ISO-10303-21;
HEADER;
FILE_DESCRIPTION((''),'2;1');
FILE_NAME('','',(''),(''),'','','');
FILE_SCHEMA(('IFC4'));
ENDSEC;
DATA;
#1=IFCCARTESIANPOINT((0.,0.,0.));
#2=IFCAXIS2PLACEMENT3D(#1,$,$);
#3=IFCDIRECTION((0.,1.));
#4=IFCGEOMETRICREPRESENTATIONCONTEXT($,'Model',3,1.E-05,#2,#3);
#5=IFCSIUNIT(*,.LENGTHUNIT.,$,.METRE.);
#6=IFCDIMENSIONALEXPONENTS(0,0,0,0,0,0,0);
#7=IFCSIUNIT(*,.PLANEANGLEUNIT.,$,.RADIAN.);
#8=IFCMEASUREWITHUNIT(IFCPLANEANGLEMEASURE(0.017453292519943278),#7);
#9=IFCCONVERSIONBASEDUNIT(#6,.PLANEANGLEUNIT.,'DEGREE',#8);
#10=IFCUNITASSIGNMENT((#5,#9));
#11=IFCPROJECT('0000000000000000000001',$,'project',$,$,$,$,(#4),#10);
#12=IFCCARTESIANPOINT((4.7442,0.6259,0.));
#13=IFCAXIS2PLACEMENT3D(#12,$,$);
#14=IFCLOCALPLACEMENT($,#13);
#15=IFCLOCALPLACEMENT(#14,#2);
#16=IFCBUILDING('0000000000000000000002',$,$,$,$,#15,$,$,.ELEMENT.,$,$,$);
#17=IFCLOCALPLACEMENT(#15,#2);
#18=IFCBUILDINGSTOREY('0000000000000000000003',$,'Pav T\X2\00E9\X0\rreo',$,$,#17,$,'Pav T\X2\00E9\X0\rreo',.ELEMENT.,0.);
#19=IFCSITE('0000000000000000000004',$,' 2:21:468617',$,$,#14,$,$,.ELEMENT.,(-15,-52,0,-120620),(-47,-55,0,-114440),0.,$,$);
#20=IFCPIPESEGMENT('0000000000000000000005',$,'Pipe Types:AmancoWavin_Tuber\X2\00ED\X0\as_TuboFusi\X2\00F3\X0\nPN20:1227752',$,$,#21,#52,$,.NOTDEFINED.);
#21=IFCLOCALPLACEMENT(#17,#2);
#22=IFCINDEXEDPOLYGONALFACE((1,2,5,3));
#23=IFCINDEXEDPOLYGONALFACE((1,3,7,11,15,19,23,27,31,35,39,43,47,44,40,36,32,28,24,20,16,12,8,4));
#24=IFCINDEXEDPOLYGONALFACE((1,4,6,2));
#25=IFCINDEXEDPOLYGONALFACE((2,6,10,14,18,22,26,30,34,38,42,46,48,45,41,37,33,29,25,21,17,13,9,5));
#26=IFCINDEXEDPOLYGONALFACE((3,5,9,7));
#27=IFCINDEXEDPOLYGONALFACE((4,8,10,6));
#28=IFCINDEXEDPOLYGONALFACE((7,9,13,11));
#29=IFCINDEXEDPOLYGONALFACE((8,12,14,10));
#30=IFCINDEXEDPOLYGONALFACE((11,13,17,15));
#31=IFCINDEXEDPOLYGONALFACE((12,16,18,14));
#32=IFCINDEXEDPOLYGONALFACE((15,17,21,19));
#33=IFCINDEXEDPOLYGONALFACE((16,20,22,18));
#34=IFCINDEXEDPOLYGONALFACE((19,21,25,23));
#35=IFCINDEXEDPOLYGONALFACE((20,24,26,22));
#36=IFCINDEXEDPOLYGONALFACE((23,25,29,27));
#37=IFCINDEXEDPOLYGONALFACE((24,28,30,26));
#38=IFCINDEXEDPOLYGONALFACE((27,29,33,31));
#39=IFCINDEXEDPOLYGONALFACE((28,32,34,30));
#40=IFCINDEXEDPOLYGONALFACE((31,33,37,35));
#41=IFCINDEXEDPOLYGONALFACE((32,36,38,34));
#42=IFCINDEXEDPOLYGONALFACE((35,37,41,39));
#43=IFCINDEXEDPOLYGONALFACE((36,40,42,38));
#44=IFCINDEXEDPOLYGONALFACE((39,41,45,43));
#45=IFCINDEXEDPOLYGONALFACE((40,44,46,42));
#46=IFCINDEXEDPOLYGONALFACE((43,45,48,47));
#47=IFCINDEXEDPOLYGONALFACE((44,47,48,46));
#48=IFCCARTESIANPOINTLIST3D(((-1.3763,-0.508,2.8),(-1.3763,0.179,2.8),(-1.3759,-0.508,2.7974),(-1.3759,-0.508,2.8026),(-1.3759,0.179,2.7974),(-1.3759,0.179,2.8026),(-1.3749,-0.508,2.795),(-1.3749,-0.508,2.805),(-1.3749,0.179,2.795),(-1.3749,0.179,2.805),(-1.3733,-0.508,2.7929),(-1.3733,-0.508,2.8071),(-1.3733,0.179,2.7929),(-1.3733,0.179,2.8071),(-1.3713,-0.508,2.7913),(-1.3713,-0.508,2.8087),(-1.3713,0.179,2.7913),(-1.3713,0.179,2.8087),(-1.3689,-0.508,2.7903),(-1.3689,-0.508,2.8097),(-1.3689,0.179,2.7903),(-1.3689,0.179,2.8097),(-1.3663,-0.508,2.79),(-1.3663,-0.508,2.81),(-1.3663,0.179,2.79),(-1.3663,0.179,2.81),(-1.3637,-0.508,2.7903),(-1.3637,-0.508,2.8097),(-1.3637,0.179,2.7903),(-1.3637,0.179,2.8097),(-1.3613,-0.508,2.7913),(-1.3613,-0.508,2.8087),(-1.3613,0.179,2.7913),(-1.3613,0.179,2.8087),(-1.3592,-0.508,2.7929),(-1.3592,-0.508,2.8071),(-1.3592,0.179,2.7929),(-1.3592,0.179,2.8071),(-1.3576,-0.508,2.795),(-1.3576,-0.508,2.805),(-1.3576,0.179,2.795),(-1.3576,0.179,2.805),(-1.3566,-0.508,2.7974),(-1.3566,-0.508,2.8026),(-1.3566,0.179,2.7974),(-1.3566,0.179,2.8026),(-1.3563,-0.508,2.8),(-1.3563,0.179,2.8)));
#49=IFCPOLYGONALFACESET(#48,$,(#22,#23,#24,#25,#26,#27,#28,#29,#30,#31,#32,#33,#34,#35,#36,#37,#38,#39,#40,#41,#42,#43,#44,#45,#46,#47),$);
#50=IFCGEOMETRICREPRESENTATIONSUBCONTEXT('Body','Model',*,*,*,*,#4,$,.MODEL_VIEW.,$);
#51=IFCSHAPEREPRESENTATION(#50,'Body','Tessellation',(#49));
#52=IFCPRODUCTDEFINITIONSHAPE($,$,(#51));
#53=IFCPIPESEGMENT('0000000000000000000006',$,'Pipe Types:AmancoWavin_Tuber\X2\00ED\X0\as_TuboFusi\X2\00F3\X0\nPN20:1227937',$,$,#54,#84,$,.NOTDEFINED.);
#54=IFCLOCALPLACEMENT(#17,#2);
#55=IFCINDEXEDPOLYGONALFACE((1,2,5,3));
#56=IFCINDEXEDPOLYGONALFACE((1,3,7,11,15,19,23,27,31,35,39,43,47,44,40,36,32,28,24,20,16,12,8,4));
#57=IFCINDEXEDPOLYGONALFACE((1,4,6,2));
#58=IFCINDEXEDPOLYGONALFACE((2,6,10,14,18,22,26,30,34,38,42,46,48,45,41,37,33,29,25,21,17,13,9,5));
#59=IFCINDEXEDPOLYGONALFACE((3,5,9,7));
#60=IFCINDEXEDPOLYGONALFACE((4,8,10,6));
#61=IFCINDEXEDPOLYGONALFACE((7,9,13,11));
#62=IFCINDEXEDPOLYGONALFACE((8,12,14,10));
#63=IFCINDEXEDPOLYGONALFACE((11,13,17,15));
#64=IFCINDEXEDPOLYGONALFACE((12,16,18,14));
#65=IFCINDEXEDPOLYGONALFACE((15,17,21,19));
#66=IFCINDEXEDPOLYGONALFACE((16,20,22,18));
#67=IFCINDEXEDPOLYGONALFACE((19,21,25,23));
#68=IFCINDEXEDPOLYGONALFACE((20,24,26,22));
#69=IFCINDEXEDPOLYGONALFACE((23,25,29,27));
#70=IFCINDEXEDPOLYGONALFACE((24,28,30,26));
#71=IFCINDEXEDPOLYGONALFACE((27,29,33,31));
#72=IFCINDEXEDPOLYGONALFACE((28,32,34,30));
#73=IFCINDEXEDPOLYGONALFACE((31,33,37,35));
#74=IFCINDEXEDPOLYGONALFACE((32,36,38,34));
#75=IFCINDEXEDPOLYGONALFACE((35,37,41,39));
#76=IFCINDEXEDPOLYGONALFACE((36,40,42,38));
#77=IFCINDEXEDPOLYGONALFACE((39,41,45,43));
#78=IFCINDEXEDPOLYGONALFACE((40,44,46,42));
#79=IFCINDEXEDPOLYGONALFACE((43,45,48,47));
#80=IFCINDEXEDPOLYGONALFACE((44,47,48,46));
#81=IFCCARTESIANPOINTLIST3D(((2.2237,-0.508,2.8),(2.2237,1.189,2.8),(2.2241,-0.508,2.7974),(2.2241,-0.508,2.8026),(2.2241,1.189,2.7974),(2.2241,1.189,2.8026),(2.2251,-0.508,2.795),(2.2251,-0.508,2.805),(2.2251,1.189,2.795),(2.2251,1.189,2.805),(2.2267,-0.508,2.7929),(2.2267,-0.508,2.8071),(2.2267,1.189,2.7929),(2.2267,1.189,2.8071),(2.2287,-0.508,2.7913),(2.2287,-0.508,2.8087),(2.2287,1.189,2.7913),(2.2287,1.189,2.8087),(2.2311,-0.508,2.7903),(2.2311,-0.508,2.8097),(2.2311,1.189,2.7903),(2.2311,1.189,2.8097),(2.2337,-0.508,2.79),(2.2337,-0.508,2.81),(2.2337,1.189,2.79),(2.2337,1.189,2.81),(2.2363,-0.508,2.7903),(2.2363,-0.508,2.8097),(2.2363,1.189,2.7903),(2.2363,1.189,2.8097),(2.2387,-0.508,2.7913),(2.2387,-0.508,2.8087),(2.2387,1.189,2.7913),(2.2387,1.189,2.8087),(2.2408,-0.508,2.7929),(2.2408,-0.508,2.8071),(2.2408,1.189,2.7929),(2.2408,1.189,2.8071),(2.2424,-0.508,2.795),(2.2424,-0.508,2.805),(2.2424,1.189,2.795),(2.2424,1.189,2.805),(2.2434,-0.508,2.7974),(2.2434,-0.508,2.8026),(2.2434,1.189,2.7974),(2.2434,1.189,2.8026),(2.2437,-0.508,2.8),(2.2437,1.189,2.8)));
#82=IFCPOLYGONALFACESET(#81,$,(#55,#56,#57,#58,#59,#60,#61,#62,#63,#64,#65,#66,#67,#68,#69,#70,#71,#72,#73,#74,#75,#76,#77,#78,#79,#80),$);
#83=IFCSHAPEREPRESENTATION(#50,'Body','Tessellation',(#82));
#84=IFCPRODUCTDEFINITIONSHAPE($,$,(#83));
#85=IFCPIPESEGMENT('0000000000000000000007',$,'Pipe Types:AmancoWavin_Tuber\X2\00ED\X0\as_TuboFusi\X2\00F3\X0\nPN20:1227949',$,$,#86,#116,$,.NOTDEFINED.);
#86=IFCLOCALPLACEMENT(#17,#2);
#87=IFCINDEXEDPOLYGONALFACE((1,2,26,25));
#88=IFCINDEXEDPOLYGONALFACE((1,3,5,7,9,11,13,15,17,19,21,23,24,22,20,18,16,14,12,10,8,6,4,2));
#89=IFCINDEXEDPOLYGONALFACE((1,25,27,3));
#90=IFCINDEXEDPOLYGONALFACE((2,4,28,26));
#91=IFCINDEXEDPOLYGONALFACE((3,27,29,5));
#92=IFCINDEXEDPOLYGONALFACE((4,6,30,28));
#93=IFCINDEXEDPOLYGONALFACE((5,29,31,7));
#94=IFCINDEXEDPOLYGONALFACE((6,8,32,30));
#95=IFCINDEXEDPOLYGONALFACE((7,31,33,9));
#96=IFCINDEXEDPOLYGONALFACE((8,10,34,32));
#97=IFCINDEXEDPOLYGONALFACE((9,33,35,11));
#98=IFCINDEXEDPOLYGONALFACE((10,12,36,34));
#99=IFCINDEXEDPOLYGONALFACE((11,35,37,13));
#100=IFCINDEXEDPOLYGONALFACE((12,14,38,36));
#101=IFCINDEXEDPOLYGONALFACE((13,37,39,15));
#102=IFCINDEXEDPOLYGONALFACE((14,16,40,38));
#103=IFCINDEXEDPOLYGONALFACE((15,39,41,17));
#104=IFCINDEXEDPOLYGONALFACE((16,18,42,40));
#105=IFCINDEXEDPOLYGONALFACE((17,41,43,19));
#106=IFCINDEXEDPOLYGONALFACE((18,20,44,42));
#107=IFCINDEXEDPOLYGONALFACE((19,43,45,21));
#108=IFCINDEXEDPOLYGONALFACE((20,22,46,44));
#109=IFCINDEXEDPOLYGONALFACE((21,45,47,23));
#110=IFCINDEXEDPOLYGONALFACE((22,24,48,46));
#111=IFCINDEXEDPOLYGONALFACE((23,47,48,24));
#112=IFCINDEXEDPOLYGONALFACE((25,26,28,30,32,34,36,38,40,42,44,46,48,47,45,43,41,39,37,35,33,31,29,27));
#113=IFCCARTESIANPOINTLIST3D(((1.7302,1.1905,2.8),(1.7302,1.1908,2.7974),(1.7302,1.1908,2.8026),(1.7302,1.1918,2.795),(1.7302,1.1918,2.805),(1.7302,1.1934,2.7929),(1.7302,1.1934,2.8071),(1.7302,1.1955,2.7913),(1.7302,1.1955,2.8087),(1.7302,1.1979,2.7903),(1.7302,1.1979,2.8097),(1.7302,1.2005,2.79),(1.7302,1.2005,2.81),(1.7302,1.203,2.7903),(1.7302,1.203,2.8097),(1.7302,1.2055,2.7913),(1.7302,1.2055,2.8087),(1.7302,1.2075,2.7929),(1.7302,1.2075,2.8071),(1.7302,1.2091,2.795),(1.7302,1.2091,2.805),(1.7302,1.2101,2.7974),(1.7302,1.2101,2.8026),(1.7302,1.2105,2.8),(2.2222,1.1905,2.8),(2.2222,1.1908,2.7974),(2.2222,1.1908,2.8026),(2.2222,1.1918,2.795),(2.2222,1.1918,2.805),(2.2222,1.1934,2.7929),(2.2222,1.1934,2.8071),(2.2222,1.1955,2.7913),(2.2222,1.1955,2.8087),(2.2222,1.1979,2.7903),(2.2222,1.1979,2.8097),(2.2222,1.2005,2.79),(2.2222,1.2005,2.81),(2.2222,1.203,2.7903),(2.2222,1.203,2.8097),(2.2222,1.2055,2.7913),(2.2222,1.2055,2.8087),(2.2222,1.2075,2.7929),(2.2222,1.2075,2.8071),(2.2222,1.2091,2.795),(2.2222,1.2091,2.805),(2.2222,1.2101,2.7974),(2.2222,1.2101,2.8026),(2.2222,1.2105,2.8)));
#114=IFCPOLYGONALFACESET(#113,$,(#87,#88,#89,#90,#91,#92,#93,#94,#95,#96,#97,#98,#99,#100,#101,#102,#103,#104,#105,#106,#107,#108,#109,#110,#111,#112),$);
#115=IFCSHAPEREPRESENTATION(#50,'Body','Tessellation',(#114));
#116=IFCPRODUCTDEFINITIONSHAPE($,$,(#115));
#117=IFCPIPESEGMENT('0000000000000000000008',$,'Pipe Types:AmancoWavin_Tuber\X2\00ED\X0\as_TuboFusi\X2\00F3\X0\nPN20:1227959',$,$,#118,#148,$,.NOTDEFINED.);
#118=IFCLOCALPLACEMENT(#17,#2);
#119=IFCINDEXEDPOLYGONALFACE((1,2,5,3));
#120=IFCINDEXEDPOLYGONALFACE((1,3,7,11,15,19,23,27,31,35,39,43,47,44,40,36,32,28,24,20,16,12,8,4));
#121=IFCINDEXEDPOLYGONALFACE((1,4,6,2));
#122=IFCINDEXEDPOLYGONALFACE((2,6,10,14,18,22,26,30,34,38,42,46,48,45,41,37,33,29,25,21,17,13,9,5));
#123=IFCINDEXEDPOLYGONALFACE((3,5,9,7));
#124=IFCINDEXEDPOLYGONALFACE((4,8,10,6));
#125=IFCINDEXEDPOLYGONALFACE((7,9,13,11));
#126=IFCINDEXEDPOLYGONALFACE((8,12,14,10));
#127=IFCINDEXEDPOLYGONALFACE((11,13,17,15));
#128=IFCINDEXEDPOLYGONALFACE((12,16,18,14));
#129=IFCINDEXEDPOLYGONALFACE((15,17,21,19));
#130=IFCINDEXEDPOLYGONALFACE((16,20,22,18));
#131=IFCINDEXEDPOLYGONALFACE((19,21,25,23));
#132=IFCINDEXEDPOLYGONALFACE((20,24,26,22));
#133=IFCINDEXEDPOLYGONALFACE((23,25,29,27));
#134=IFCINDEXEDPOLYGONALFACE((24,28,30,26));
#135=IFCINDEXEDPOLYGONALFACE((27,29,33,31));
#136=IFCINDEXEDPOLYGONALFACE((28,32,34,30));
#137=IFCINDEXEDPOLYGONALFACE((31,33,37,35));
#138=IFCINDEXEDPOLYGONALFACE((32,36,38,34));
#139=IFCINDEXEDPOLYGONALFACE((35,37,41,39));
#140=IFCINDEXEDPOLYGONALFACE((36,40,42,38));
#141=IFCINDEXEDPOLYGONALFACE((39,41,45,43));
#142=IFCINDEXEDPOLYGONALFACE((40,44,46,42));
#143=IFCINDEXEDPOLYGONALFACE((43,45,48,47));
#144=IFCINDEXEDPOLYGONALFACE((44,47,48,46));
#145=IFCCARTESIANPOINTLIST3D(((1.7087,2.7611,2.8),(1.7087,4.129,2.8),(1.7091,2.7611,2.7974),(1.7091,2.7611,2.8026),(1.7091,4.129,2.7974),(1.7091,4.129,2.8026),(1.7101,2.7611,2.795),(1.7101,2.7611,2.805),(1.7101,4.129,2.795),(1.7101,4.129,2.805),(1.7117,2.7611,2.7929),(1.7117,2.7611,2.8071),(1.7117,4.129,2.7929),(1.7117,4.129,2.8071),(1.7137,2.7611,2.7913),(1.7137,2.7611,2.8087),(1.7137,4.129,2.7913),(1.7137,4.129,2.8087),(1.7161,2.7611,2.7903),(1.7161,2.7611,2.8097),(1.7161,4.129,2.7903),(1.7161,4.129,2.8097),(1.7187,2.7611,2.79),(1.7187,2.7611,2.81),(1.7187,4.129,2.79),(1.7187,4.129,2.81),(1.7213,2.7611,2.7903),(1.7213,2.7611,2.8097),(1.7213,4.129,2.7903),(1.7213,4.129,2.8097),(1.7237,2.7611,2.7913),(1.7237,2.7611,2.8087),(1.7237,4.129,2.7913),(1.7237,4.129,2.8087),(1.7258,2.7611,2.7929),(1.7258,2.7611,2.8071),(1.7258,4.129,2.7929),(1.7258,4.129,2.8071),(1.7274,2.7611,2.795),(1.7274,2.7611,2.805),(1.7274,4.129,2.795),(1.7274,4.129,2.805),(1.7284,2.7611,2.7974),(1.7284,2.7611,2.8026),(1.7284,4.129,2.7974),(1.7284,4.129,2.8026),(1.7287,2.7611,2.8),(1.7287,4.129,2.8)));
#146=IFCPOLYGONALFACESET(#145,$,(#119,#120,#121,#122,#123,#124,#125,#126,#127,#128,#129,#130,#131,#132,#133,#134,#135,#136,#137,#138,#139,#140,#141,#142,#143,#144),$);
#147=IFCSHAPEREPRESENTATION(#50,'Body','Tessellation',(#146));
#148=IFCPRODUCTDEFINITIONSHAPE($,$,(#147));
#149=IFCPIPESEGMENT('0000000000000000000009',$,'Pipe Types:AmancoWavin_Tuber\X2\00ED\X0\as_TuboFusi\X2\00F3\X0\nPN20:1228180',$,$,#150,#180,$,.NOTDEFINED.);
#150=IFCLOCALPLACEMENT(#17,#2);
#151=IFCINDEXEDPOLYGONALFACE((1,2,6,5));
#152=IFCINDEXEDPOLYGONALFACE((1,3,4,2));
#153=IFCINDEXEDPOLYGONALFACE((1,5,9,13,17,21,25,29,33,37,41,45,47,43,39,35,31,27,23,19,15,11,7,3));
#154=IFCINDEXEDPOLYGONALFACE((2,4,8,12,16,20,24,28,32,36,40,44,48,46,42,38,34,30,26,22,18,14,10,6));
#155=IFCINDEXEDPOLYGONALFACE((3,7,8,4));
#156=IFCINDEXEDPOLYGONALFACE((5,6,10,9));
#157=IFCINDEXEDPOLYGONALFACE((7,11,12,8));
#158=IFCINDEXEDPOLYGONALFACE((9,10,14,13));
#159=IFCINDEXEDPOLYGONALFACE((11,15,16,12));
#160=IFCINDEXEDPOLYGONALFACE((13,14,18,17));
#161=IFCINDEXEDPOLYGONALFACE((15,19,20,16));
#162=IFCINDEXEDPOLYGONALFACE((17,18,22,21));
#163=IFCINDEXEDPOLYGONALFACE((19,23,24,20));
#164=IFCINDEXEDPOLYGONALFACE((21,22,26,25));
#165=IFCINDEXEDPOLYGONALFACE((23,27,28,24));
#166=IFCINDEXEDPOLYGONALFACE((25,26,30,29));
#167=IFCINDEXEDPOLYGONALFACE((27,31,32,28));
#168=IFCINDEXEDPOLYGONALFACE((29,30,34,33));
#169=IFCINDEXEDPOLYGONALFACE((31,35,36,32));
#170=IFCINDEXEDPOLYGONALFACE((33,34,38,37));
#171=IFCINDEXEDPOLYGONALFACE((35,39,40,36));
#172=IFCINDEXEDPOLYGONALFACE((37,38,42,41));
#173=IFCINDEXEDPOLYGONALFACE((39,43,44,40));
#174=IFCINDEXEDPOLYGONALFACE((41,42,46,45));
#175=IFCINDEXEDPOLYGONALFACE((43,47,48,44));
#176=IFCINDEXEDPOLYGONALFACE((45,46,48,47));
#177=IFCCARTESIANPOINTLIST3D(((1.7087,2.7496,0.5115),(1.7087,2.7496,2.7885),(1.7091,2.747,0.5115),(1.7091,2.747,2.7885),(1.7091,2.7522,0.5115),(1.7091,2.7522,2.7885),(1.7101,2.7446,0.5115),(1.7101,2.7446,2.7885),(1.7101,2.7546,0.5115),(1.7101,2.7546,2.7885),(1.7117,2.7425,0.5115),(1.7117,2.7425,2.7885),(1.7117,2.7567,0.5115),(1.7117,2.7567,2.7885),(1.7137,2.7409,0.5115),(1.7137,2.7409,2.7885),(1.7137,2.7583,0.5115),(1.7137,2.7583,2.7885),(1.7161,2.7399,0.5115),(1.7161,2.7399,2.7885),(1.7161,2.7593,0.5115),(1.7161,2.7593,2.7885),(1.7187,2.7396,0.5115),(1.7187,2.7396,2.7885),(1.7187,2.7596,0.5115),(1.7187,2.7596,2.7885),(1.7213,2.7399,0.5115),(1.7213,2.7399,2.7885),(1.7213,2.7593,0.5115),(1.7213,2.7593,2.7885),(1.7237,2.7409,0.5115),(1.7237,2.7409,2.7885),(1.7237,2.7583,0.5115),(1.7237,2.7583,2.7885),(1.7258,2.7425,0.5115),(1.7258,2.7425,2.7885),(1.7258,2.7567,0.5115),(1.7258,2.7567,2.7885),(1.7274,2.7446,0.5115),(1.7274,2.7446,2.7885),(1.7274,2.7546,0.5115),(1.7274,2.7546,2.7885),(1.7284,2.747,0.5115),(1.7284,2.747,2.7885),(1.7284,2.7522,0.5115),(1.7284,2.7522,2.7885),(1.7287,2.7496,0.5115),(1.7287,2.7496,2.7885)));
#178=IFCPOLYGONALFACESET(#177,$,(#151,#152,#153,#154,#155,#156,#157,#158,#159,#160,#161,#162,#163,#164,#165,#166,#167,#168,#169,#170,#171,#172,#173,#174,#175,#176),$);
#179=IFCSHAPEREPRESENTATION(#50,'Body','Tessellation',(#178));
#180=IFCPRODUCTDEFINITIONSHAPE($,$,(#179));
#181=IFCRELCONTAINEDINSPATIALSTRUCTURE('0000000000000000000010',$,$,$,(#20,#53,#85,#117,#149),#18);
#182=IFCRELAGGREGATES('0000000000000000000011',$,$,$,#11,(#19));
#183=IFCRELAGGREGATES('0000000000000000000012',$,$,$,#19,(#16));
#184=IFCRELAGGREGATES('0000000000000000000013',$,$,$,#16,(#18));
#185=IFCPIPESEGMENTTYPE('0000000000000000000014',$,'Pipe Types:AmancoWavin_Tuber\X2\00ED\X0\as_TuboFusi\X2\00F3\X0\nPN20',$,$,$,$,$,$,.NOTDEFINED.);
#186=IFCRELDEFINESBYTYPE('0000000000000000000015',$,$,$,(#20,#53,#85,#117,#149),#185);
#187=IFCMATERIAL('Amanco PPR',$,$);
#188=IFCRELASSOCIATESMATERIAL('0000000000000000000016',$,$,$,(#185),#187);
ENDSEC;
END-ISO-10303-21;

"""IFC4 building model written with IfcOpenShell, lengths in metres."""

from ifc_helpers import new_model, entity, si_unit, converted_unit, direction, frame, origin, place, context, subcontext, project, spatial, arc, indexed_curve, outline, extrude, material, type_object, element, save


model = new_model("IFC4")

# Units and contexts
model_context = context("Model", 3, precision=1e-05, world=origin(), true_north=direction((0.0, 1.0)))
body_context = subcontext(model_context, "Body", "Model", "MODEL_VIEW")
ifc_project = project(units=[si_unit("LENGTHUNIT", "METRE"), converted_unit("PLANEANGLEUNIT", "DEGREE", entity("IfcPlaneAngleMeasure", 0.017453292519943278), si_unit("PLANEANGLEUNIT", "RADIAN"), dimensions=[0, 0, 0, 0, 0, 0, 0])], contexts=[model_context])

# Site, building, storey
site_placement = place(None, frame((4.7442, 0.6259, 0.0)))
site = spatial("IfcSite", under=ifc_project, at=site_placement, Name=" 2:21:468617", CompositionType="ELEMENT", RefLatitude=(-15, -52, 0, -120620), RefLongitude=(-47, -55, 0, -114440), RefElevation=0.0)
building_placement = place(site_placement, origin())
building = spatial("IfcBuilding", under=site, at=building_placement, CompositionType="ELEMENT")
storey_placement = place(building_placement, origin())
storey = spatial("IfcBuildingStorey", under=building, at=storey_placement, Name="Pav Térreo", LongName="Pav Térreo", CompositionType="ELEMENT", Elevation=0.0)

# Pipe segments
ifc_material_1 = material(Name="Amanco PPR")
pipe_segment_type_1 = type_object("IfcPipeSegmentType", Name="Pipe Types:AmancoWavin_Tuberías_TuboFusiónPN20", PredefinedType="NOTDEFINED", material=ifc_material_1)
pipe_segment_1_placement = place(storey_placement, origin())
element("IfcPipeSegment", 1, at=pipe_segment_1_placement, inside=storey, type_object=pipe_segment_type_1, Name="Pipe Types:AmancoWavin_Tuberías_TuboFusiónPN20:1227752", PredefinedType="NOTDEFINED", context=body_context, shape_type="SweptSolid", body=[
    extrude(outline(indexed_curve([(0.01, 0.0), (0.0071, 0.0071), (0.0, 0.01), (-0.0071, 0.0071), (-0.01, 0.0), (-0.0071, -0.0071), (0.0, -0.01), (0.0071, -0.0071)], segments=[arc(1, 2, 3), arc(3, 4, 5), arc(5, 6, 7), arc(7, 8, 1)], self_intersect=False)), frame((-1.3663, -0.508, 2.8), z_axis=(0.0, 1.0, 0.0), x_axis=(-1.0, 0.0, 0.0)), (0.0, 0.0, 1.0), 0.687),
])
pipe_segment_2_placement = place(storey_placement, origin())
element("IfcPipeSegment", 2, at=pipe_segment_2_placement, inside=storey, type_object=pipe_segment_type_1, Name="Pipe Types:AmancoWavin_Tuberías_TuboFusiónPN20:1227937", PredefinedType="NOTDEFINED", context=body_context, shape_type="SweptSolid", body=[
    extrude(outline(indexed_curve([(0.01, 0.0), (0.0071, 0.0071), (0.0, 0.01), (-0.0071, 0.0071), (-0.01, 0.0), (-0.0071, -0.0071), (0.0, -0.01), (0.0071, -0.0071)], segments=[arc(1, 2, 3), arc(3, 4, 5), arc(5, 6, 7), arc(7, 8, 1)], self_intersect=False)), frame((2.2337, -0.508, 2.8), z_axis=(0.0, 1.0, 0.0), x_axis=(1.0, 0.0, 0.0)), (0.0, 0.0, 1.0), 1.697),
])
pipe_segment_3_placement = place(storey_placement, origin())
element("IfcPipeSegment", 3, at=pipe_segment_3_placement, inside=storey, type_object=pipe_segment_type_1, Name="Pipe Types:AmancoWavin_Tuberías_TuboFusiónPN20:1227949", PredefinedType="NOTDEFINED", context=body_context, shape_type="SweptSolid", body=[
    extrude(outline(indexed_curve([(0.01, 0.0), (0.0071, 0.0071), (0.0, 0.01), (-0.0071, 0.0071), (-0.01, 0.0), (-0.0071, -0.0071), (0.0, -0.01), (0.0071, -0.0071)], segments=[arc(1, 2, 3), arc(3, 4, 5), arc(5, 6, 7), arc(7, 8, 1)], self_intersect=False)), frame((1.7302, 1.2005, 2.8), z_axis=(1.0, 0.0, 0.0), x_axis=(0.0, 1.0, 0.0)), (0.0, 0.0, 1.0), 0.492),
])
pipe_segment_4_placement = place(storey_placement, origin())
element("IfcPipeSegment", 4, at=pipe_segment_4_placement, inside=storey, type_object=pipe_segment_type_1, Name="Pipe Types:AmancoWavin_Tuberías_TuboFusiónPN20:1227959", PredefinedType="NOTDEFINED", context=body_context, shape_type="SweptSolid", body=[
    extrude(outline(indexed_curve([(0.01, 0.0), (0.0071, 0.0071), (0.0, 0.01), (-0.0071, 0.0071), (-0.01, 0.0), (-0.0071, -0.0071), (0.0, -0.01), (0.0071, -0.0071)], segments=[arc(1, 2, 3), arc(3, 4, 5), arc(5, 6, 7), arc(7, 8, 1)], self_intersect=False)), frame((1.7187, 2.7611, 2.8), z_axis=(0.0, 1.0, 0.0), x_axis=(1.0, 0.0, 0.0)), (0.0, 0.0, 1.0), 1.3679),
])
pipe_segment_5_placement = place(storey_placement, origin())
element("IfcPipeSegment", 5, at=pipe_segment_5_placement, inside=storey, type_object=pipe_segment_type_1, Name="Pipe Types:AmancoWavin_Tuberías_TuboFusiónPN20:1228180", PredefinedType="NOTDEFINED", context=body_context, shape_type="SweptSolid", body=[
    extrude(outline(indexed_curve([(0.01, 0.0), (0.0071, 0.0071), (0.0, 0.01), (-0.0071, 0.0071), (-0.01, 0.0), (-0.0071, -0.0071), (0.0, -0.01), (0.0071, -0.0071)], segments=[arc(1, 2, 3), arc(3, 4, 5), arc(5, 6, 7), arc(7, 8, 1)], self_intersect=False)), frame((1.7187, 2.7496, 0.5115)), (0.0, 0.0, 1.0), 2.277),
])

save(model, "model.ifc")
